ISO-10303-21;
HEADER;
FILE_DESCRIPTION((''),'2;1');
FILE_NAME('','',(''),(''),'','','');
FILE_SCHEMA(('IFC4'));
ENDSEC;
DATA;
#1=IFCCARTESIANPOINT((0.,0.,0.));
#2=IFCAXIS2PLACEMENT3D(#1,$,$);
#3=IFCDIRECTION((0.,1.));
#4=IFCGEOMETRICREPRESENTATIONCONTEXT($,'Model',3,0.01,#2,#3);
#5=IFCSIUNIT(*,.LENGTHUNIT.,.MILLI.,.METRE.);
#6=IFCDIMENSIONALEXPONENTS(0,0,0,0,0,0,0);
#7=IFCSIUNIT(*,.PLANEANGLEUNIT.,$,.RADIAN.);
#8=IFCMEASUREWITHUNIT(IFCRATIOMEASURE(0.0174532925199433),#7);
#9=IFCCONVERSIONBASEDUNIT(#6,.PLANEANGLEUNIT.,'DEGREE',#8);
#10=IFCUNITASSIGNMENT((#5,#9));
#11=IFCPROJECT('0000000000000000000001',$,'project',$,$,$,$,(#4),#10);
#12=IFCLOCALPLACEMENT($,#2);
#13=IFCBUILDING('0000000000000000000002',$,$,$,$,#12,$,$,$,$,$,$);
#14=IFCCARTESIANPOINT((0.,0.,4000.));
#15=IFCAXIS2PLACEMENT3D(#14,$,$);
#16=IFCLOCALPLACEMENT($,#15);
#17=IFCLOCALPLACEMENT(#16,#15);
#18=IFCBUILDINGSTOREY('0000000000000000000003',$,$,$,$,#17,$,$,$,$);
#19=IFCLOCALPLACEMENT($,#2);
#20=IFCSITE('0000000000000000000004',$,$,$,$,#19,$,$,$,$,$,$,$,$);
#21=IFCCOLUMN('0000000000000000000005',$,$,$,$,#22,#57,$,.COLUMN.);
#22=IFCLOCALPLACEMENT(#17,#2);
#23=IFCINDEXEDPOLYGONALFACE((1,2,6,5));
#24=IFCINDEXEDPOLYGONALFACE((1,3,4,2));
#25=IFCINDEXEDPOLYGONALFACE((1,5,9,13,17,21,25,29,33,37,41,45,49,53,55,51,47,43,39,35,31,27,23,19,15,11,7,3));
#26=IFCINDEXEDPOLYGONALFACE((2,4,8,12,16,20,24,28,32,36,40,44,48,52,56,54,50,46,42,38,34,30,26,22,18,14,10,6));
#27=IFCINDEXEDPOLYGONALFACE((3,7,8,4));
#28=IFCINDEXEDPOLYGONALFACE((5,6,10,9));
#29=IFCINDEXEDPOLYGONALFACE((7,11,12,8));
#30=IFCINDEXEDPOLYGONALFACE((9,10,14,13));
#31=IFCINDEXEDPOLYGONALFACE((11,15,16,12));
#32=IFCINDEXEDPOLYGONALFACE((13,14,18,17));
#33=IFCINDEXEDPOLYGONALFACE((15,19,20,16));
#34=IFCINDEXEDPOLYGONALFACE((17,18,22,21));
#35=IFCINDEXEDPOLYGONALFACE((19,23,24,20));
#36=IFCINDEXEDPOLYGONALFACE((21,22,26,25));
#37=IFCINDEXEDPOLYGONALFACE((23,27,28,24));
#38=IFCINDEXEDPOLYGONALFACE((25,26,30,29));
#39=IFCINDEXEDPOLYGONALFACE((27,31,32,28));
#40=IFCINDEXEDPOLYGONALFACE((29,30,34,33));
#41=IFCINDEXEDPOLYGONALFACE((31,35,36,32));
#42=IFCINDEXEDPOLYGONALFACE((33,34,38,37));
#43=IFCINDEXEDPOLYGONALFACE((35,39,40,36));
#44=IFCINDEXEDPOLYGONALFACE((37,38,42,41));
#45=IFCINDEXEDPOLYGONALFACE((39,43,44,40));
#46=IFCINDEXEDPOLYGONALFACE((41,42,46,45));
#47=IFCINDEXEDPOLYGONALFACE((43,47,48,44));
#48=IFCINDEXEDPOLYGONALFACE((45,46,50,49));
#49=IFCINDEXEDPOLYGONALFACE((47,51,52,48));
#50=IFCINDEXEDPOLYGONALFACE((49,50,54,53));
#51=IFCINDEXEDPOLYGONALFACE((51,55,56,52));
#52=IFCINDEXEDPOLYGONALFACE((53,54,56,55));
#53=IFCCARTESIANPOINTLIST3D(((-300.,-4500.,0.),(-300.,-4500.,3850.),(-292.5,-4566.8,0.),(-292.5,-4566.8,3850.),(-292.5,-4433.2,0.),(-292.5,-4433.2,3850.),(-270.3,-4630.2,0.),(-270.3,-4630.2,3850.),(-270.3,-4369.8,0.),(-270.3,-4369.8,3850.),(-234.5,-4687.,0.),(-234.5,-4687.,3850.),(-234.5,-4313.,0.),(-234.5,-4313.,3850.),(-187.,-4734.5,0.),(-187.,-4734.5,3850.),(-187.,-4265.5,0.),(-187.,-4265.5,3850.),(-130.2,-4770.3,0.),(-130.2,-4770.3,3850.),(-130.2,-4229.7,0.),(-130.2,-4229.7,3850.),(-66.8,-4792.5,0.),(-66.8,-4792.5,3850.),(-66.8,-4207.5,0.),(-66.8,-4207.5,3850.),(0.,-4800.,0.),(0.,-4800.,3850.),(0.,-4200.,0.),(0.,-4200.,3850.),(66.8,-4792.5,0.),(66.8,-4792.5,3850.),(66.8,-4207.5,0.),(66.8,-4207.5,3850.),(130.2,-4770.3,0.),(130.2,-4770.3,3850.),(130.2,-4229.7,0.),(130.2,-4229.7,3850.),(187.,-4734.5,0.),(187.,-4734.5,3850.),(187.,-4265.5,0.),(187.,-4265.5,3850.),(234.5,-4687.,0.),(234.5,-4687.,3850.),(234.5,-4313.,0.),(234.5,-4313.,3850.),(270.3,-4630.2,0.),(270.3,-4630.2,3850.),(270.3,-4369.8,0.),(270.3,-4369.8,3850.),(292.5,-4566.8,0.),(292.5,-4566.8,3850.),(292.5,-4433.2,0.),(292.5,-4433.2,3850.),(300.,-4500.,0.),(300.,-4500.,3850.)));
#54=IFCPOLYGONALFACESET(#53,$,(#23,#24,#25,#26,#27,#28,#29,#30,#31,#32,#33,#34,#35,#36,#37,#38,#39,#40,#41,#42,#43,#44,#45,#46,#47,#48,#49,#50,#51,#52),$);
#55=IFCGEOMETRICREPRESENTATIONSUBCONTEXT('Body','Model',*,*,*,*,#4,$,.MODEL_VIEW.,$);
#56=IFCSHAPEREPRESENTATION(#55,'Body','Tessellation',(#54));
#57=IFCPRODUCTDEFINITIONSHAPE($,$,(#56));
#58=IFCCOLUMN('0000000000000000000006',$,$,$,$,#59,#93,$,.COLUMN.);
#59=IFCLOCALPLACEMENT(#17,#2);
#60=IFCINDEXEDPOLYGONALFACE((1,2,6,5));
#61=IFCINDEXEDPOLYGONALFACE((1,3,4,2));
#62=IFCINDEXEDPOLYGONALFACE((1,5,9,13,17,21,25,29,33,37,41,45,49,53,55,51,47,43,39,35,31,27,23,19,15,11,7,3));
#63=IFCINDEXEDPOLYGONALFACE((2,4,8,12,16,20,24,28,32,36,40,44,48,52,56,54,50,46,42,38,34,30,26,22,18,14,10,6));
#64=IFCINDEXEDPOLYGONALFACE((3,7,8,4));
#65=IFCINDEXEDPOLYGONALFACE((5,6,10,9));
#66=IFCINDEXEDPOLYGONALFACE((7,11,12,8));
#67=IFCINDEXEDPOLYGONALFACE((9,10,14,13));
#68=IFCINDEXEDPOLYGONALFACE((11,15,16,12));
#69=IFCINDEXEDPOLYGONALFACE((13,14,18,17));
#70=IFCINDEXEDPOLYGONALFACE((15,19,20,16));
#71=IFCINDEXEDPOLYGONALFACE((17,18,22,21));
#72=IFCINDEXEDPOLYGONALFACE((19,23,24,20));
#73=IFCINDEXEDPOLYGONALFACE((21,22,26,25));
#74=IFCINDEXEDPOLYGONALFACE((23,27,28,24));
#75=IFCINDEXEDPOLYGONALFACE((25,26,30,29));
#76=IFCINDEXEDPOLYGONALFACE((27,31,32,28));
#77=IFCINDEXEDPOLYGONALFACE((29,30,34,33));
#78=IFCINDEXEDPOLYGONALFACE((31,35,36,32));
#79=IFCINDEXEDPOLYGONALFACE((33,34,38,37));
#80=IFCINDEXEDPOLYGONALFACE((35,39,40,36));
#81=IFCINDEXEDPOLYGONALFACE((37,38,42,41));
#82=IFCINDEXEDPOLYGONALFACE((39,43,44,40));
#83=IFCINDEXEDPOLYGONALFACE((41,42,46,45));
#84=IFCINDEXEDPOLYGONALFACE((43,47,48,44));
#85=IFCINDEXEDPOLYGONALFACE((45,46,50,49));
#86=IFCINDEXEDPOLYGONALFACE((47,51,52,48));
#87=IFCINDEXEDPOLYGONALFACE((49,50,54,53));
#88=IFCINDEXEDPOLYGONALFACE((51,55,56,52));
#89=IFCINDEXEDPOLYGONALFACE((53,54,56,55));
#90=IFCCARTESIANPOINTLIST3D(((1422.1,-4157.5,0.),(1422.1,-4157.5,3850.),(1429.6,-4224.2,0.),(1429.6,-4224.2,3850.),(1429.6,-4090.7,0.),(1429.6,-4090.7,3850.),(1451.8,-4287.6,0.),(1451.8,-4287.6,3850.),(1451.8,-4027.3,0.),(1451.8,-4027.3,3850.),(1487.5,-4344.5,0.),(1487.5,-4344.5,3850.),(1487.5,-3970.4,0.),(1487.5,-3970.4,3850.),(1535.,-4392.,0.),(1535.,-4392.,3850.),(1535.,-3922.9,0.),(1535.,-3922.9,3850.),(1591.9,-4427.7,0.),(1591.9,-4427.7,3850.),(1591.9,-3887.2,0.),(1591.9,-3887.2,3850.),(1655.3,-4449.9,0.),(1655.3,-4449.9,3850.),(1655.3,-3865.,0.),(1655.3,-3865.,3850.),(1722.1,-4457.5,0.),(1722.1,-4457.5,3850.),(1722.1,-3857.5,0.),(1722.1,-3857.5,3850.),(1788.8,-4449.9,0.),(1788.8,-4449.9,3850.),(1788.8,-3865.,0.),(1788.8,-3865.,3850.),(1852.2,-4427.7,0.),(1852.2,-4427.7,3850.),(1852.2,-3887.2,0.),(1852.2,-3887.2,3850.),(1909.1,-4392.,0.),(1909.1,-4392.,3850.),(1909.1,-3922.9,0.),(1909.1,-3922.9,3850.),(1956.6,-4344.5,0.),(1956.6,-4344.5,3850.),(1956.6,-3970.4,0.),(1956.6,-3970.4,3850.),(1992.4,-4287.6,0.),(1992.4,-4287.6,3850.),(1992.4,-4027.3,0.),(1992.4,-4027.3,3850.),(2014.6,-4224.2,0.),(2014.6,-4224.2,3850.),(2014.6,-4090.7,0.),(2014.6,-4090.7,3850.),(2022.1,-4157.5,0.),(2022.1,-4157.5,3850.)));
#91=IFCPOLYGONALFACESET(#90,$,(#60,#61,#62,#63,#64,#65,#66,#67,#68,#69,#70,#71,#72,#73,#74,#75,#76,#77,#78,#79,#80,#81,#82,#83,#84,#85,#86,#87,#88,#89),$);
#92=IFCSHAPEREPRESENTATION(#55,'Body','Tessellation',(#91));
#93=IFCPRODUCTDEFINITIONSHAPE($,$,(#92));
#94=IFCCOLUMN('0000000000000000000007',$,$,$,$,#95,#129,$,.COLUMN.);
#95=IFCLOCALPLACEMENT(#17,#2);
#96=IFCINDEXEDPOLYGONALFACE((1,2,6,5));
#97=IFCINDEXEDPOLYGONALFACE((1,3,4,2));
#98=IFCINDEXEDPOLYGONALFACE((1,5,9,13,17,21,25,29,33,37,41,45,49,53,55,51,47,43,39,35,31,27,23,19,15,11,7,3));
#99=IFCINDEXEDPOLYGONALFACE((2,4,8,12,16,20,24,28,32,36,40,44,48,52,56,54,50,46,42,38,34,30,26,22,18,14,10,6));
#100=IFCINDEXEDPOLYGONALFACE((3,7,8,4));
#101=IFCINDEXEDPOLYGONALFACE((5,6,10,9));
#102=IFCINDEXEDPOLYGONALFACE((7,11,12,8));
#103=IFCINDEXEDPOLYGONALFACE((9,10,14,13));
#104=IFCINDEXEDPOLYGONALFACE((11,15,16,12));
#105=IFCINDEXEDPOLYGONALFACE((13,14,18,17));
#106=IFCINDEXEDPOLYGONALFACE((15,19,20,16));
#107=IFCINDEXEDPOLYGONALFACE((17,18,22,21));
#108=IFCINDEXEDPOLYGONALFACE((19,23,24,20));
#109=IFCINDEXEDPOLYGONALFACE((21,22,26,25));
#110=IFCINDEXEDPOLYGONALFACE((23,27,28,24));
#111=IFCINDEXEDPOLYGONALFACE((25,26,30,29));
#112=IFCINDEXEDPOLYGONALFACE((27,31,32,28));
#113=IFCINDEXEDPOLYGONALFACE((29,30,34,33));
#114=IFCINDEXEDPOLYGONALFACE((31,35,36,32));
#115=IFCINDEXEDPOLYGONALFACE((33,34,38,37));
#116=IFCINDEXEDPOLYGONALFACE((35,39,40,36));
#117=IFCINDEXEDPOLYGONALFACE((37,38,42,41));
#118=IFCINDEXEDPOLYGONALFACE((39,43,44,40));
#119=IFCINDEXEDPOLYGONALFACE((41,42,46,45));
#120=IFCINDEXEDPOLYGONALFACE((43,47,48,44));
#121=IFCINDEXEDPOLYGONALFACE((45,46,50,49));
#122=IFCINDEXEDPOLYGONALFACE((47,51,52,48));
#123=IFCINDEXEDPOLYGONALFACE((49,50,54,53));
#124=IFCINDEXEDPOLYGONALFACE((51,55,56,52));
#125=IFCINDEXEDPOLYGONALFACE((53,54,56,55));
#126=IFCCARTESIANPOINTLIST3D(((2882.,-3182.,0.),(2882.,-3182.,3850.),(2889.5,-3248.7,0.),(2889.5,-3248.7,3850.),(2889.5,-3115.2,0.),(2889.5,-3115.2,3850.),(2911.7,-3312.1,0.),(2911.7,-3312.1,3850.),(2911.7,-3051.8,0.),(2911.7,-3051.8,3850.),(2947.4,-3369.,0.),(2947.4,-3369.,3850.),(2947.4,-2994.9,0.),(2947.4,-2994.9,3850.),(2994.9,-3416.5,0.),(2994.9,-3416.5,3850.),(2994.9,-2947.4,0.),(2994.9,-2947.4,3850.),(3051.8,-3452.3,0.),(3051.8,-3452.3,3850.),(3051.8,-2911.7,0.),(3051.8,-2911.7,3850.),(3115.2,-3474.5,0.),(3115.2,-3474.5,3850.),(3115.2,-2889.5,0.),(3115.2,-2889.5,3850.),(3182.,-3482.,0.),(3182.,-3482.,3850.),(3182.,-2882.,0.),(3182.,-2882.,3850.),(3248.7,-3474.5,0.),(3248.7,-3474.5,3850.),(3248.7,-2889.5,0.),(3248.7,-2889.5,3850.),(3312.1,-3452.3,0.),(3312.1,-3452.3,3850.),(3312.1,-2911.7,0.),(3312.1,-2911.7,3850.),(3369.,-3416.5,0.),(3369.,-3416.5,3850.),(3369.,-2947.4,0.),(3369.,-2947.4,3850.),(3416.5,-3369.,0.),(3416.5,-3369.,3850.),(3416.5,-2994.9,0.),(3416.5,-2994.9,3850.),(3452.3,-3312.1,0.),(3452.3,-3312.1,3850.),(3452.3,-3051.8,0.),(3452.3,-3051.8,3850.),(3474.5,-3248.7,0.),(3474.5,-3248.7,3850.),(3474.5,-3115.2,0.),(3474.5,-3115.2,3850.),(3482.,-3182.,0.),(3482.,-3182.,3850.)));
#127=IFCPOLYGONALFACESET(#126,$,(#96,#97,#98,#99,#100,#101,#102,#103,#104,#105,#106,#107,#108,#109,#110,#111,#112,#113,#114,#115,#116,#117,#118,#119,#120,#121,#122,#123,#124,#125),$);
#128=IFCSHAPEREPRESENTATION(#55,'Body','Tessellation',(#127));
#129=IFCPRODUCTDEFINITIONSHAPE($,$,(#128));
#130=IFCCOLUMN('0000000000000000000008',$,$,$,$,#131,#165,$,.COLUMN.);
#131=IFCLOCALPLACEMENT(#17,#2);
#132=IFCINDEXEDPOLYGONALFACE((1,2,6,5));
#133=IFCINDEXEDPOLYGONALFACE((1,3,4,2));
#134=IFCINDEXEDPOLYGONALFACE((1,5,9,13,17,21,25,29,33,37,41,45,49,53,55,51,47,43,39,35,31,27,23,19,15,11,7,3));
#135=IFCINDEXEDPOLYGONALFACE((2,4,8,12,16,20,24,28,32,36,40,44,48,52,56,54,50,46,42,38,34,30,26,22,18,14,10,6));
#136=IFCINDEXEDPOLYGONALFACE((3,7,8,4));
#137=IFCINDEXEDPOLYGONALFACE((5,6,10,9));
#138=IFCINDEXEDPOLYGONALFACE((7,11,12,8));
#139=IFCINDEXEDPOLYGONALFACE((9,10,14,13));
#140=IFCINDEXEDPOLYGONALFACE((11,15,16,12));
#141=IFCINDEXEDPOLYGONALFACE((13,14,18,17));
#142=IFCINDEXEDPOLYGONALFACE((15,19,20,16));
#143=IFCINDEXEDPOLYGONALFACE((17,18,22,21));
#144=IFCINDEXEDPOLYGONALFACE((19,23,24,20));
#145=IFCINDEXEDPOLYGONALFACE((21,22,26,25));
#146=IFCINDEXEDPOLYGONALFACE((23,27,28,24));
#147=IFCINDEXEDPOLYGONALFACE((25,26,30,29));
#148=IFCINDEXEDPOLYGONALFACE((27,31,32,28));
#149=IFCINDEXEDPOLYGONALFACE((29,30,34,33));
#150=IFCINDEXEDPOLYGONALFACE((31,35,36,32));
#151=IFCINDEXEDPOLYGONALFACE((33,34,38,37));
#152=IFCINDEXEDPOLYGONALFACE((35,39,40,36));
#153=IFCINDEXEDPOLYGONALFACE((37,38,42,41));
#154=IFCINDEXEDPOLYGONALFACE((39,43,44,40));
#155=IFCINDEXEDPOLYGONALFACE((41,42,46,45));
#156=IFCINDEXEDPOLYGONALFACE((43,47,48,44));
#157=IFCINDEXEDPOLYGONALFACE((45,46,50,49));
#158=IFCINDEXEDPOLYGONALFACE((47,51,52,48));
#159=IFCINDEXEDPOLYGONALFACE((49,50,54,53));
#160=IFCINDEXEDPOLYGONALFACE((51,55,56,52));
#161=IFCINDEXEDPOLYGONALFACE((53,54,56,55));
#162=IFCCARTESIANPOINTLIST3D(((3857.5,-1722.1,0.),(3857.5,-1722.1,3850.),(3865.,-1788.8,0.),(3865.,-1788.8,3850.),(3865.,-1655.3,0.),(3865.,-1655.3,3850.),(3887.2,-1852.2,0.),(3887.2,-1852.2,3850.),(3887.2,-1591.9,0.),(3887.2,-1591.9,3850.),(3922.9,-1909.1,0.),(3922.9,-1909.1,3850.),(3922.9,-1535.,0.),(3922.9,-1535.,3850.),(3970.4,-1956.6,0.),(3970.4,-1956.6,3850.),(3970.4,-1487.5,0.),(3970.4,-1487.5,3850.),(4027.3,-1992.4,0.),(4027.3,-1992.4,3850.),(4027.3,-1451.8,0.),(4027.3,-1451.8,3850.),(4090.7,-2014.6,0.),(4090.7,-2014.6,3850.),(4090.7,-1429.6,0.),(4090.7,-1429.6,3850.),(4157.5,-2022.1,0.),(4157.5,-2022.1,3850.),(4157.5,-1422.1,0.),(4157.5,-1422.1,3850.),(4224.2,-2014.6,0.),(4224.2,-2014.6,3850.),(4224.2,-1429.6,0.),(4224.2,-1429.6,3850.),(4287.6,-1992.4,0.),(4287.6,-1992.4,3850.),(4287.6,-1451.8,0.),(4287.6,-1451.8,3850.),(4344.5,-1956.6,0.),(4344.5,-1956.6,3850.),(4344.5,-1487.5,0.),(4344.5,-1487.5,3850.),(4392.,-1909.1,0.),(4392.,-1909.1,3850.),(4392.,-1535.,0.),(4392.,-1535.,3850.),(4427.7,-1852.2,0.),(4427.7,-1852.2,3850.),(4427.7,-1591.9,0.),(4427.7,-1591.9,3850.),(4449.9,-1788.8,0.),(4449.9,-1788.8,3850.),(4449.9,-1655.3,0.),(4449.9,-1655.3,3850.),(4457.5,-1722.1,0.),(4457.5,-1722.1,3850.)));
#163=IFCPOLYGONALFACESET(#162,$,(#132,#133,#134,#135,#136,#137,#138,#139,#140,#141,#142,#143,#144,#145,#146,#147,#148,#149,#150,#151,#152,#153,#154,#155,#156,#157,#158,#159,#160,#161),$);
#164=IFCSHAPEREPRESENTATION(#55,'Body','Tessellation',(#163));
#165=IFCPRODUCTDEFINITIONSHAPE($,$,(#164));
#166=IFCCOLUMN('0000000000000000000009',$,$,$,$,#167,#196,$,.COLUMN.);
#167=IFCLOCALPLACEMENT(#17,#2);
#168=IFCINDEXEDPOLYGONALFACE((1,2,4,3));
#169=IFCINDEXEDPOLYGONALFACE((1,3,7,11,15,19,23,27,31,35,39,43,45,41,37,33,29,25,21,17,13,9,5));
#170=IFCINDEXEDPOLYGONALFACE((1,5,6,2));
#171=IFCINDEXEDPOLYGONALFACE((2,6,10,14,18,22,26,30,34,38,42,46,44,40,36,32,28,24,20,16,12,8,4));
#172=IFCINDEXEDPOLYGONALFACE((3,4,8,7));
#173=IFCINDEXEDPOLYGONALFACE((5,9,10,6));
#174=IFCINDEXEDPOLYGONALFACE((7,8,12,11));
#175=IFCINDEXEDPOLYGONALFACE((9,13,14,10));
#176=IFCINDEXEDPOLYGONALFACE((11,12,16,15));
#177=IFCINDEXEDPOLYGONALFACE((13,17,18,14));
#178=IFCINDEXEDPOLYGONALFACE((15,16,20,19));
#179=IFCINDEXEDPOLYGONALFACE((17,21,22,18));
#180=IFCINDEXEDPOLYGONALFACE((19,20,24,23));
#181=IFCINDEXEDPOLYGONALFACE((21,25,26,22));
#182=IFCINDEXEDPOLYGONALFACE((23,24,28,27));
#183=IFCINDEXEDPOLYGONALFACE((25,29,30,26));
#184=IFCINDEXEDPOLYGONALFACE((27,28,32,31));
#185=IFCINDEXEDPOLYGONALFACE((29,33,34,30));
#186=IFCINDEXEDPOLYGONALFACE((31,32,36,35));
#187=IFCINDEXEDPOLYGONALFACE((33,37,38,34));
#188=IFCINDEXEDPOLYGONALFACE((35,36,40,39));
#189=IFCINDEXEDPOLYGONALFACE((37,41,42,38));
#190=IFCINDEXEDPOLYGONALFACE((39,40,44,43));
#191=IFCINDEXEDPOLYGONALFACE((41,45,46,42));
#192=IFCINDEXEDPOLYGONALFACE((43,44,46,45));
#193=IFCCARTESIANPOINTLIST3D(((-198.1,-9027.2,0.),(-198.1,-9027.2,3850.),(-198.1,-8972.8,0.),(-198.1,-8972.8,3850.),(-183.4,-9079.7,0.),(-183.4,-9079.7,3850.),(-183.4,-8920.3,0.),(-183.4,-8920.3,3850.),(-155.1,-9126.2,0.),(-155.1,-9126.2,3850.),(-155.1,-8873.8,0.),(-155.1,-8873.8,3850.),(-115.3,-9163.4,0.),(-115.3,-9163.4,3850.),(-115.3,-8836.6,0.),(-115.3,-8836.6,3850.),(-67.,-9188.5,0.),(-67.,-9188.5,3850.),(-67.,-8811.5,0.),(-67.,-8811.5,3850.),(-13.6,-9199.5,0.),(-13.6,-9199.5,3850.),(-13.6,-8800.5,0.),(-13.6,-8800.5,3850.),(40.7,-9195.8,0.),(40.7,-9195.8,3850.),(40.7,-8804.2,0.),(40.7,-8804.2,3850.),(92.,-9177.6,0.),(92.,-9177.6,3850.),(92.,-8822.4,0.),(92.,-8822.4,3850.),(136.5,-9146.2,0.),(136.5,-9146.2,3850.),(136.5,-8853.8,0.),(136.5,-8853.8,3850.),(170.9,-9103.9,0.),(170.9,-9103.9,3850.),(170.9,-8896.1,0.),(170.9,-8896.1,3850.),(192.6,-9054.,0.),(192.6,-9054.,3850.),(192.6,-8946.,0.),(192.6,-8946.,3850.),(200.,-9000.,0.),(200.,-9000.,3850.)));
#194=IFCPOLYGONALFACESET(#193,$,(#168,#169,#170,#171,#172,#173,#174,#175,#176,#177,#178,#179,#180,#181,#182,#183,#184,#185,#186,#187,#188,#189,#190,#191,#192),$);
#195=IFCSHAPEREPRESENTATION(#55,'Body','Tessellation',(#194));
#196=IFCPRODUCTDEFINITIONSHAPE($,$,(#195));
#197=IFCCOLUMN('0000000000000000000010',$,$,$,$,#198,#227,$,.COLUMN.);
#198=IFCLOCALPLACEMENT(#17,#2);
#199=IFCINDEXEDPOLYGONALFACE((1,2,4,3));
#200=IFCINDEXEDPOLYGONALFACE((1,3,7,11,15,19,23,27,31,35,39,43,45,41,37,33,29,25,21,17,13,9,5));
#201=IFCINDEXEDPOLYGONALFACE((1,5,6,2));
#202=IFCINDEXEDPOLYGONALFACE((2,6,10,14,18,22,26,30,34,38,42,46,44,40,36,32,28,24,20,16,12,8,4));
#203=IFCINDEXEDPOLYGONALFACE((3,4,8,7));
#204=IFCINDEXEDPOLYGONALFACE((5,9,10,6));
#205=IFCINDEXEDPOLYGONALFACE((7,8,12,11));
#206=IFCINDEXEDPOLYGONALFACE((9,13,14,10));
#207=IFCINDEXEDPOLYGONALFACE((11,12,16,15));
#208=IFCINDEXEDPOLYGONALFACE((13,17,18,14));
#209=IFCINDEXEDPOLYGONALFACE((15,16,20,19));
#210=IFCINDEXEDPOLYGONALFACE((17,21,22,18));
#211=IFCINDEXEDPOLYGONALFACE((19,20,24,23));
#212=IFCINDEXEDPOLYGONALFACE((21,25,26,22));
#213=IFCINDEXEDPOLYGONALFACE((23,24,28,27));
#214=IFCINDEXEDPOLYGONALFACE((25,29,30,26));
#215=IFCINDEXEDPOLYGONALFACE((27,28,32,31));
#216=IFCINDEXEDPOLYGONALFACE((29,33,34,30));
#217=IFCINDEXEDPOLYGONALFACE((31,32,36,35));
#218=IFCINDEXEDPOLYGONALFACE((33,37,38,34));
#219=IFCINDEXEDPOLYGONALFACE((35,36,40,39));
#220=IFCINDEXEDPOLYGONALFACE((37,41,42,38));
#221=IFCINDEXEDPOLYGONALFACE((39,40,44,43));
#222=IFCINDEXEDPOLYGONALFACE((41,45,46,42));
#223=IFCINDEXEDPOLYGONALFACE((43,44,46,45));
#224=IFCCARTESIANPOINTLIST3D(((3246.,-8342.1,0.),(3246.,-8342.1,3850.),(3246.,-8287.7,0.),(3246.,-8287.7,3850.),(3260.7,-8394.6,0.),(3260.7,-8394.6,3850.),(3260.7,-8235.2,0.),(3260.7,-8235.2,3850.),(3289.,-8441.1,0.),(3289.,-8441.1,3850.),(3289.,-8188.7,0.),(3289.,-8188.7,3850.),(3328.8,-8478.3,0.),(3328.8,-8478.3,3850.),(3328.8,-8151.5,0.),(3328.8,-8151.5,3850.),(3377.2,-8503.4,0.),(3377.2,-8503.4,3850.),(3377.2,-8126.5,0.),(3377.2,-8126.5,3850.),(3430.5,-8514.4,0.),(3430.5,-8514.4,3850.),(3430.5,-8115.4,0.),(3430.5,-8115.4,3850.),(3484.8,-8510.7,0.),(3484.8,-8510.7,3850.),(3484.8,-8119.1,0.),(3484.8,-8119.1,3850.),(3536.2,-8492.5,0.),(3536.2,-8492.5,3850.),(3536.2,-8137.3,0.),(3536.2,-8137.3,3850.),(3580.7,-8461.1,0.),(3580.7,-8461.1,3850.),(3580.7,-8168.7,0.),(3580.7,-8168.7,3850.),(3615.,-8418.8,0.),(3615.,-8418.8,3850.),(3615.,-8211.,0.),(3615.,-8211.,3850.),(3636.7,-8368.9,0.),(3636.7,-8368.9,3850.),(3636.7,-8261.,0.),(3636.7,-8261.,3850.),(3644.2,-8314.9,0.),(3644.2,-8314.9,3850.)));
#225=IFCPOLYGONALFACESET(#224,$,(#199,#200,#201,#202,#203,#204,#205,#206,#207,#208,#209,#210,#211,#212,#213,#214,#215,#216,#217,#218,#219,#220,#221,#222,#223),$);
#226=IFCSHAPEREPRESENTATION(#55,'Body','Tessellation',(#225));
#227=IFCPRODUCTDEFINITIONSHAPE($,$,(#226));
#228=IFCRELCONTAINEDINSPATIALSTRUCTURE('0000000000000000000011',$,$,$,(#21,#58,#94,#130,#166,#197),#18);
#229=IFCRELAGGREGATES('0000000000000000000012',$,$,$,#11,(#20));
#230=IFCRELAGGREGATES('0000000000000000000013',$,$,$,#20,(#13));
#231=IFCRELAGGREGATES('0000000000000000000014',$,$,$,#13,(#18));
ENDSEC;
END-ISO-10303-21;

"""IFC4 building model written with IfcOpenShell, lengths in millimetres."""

from ifc_helpers import new_model, entity, si_unit, converted_unit, direction, frame, origin, origin_2d, place, context, subcontext, project, spatial, circle, extrude, element, save


model = new_model("IFC4")

# Units and contexts
model_context = context("Model", 3, precision=0.01, world=origin(), true_north=direction((0.0, 1.0)))
body_context = subcontext(model_context, "Body", "Model", "MODEL_VIEW")
ifc_project = project(units=[si_unit("LENGTHUNIT", "METRE", prefix="MILLI"), converted_unit("PLANEANGLEUNIT", "DEGREE", entity("IfcRatioMeasure", 0.0174532925199433), si_unit("PLANEANGLEUNIT", "RADIAN"), dimensions=[0, 0, 0, 0, 0, 0, 0])], contexts=[model_context])

# Site, building, storey
site_placement = place(None, origin())
site = spatial("IfcSite", under=ifc_project, at=site_placement)
building_placement = place(None, origin())
building = spatial("IfcBuilding", under=site, at=building_placement)
placement = place(None, frame((0.0, 0.0, 4000.0)))
storey_placement = place(placement, frame((0.0, 0.0, 4000.0)))
storey = spatial("IfcBuildingStorey", under=building, at=storey_placement)

# Columns
for number, where in (
    (1, (0.0, -4500.0, 0.0)),
    (2, (1722.1, -4157.5, 0.0)),
    (3, (3182.0, -3182.0, 0.0)),
    (4, (4157.5, -1722.1, 0.0)),
):
    element("IfcColumn", number, at=place(storey_placement, frame(where)), inside=storey, PredefinedType="COLUMN", context=body_context, shape_type="SweptSolid", body=[
        extrude(circle(Radius=300.0, at=origin_2d()), origin(), (0.0, 0.0, 1.0), 3850.0),
    ])
for number, where in (
    (5, (0.0, -9000.0, 0.0)),
    (6, (3444.2, -8314.9, 0.0)),
):
    element("IfcColumn", number, at=place(storey_placement, frame(where)), inside=storey, PredefinedType="COLUMN", context=body_context, shape_type="SweptSolid", body=[
        extrude(circle(Radius=200.0, at=origin_2d()), origin(), (0.0, 0.0, 1.0), 3850.0),
    ])

save(model, "model.ifc")
